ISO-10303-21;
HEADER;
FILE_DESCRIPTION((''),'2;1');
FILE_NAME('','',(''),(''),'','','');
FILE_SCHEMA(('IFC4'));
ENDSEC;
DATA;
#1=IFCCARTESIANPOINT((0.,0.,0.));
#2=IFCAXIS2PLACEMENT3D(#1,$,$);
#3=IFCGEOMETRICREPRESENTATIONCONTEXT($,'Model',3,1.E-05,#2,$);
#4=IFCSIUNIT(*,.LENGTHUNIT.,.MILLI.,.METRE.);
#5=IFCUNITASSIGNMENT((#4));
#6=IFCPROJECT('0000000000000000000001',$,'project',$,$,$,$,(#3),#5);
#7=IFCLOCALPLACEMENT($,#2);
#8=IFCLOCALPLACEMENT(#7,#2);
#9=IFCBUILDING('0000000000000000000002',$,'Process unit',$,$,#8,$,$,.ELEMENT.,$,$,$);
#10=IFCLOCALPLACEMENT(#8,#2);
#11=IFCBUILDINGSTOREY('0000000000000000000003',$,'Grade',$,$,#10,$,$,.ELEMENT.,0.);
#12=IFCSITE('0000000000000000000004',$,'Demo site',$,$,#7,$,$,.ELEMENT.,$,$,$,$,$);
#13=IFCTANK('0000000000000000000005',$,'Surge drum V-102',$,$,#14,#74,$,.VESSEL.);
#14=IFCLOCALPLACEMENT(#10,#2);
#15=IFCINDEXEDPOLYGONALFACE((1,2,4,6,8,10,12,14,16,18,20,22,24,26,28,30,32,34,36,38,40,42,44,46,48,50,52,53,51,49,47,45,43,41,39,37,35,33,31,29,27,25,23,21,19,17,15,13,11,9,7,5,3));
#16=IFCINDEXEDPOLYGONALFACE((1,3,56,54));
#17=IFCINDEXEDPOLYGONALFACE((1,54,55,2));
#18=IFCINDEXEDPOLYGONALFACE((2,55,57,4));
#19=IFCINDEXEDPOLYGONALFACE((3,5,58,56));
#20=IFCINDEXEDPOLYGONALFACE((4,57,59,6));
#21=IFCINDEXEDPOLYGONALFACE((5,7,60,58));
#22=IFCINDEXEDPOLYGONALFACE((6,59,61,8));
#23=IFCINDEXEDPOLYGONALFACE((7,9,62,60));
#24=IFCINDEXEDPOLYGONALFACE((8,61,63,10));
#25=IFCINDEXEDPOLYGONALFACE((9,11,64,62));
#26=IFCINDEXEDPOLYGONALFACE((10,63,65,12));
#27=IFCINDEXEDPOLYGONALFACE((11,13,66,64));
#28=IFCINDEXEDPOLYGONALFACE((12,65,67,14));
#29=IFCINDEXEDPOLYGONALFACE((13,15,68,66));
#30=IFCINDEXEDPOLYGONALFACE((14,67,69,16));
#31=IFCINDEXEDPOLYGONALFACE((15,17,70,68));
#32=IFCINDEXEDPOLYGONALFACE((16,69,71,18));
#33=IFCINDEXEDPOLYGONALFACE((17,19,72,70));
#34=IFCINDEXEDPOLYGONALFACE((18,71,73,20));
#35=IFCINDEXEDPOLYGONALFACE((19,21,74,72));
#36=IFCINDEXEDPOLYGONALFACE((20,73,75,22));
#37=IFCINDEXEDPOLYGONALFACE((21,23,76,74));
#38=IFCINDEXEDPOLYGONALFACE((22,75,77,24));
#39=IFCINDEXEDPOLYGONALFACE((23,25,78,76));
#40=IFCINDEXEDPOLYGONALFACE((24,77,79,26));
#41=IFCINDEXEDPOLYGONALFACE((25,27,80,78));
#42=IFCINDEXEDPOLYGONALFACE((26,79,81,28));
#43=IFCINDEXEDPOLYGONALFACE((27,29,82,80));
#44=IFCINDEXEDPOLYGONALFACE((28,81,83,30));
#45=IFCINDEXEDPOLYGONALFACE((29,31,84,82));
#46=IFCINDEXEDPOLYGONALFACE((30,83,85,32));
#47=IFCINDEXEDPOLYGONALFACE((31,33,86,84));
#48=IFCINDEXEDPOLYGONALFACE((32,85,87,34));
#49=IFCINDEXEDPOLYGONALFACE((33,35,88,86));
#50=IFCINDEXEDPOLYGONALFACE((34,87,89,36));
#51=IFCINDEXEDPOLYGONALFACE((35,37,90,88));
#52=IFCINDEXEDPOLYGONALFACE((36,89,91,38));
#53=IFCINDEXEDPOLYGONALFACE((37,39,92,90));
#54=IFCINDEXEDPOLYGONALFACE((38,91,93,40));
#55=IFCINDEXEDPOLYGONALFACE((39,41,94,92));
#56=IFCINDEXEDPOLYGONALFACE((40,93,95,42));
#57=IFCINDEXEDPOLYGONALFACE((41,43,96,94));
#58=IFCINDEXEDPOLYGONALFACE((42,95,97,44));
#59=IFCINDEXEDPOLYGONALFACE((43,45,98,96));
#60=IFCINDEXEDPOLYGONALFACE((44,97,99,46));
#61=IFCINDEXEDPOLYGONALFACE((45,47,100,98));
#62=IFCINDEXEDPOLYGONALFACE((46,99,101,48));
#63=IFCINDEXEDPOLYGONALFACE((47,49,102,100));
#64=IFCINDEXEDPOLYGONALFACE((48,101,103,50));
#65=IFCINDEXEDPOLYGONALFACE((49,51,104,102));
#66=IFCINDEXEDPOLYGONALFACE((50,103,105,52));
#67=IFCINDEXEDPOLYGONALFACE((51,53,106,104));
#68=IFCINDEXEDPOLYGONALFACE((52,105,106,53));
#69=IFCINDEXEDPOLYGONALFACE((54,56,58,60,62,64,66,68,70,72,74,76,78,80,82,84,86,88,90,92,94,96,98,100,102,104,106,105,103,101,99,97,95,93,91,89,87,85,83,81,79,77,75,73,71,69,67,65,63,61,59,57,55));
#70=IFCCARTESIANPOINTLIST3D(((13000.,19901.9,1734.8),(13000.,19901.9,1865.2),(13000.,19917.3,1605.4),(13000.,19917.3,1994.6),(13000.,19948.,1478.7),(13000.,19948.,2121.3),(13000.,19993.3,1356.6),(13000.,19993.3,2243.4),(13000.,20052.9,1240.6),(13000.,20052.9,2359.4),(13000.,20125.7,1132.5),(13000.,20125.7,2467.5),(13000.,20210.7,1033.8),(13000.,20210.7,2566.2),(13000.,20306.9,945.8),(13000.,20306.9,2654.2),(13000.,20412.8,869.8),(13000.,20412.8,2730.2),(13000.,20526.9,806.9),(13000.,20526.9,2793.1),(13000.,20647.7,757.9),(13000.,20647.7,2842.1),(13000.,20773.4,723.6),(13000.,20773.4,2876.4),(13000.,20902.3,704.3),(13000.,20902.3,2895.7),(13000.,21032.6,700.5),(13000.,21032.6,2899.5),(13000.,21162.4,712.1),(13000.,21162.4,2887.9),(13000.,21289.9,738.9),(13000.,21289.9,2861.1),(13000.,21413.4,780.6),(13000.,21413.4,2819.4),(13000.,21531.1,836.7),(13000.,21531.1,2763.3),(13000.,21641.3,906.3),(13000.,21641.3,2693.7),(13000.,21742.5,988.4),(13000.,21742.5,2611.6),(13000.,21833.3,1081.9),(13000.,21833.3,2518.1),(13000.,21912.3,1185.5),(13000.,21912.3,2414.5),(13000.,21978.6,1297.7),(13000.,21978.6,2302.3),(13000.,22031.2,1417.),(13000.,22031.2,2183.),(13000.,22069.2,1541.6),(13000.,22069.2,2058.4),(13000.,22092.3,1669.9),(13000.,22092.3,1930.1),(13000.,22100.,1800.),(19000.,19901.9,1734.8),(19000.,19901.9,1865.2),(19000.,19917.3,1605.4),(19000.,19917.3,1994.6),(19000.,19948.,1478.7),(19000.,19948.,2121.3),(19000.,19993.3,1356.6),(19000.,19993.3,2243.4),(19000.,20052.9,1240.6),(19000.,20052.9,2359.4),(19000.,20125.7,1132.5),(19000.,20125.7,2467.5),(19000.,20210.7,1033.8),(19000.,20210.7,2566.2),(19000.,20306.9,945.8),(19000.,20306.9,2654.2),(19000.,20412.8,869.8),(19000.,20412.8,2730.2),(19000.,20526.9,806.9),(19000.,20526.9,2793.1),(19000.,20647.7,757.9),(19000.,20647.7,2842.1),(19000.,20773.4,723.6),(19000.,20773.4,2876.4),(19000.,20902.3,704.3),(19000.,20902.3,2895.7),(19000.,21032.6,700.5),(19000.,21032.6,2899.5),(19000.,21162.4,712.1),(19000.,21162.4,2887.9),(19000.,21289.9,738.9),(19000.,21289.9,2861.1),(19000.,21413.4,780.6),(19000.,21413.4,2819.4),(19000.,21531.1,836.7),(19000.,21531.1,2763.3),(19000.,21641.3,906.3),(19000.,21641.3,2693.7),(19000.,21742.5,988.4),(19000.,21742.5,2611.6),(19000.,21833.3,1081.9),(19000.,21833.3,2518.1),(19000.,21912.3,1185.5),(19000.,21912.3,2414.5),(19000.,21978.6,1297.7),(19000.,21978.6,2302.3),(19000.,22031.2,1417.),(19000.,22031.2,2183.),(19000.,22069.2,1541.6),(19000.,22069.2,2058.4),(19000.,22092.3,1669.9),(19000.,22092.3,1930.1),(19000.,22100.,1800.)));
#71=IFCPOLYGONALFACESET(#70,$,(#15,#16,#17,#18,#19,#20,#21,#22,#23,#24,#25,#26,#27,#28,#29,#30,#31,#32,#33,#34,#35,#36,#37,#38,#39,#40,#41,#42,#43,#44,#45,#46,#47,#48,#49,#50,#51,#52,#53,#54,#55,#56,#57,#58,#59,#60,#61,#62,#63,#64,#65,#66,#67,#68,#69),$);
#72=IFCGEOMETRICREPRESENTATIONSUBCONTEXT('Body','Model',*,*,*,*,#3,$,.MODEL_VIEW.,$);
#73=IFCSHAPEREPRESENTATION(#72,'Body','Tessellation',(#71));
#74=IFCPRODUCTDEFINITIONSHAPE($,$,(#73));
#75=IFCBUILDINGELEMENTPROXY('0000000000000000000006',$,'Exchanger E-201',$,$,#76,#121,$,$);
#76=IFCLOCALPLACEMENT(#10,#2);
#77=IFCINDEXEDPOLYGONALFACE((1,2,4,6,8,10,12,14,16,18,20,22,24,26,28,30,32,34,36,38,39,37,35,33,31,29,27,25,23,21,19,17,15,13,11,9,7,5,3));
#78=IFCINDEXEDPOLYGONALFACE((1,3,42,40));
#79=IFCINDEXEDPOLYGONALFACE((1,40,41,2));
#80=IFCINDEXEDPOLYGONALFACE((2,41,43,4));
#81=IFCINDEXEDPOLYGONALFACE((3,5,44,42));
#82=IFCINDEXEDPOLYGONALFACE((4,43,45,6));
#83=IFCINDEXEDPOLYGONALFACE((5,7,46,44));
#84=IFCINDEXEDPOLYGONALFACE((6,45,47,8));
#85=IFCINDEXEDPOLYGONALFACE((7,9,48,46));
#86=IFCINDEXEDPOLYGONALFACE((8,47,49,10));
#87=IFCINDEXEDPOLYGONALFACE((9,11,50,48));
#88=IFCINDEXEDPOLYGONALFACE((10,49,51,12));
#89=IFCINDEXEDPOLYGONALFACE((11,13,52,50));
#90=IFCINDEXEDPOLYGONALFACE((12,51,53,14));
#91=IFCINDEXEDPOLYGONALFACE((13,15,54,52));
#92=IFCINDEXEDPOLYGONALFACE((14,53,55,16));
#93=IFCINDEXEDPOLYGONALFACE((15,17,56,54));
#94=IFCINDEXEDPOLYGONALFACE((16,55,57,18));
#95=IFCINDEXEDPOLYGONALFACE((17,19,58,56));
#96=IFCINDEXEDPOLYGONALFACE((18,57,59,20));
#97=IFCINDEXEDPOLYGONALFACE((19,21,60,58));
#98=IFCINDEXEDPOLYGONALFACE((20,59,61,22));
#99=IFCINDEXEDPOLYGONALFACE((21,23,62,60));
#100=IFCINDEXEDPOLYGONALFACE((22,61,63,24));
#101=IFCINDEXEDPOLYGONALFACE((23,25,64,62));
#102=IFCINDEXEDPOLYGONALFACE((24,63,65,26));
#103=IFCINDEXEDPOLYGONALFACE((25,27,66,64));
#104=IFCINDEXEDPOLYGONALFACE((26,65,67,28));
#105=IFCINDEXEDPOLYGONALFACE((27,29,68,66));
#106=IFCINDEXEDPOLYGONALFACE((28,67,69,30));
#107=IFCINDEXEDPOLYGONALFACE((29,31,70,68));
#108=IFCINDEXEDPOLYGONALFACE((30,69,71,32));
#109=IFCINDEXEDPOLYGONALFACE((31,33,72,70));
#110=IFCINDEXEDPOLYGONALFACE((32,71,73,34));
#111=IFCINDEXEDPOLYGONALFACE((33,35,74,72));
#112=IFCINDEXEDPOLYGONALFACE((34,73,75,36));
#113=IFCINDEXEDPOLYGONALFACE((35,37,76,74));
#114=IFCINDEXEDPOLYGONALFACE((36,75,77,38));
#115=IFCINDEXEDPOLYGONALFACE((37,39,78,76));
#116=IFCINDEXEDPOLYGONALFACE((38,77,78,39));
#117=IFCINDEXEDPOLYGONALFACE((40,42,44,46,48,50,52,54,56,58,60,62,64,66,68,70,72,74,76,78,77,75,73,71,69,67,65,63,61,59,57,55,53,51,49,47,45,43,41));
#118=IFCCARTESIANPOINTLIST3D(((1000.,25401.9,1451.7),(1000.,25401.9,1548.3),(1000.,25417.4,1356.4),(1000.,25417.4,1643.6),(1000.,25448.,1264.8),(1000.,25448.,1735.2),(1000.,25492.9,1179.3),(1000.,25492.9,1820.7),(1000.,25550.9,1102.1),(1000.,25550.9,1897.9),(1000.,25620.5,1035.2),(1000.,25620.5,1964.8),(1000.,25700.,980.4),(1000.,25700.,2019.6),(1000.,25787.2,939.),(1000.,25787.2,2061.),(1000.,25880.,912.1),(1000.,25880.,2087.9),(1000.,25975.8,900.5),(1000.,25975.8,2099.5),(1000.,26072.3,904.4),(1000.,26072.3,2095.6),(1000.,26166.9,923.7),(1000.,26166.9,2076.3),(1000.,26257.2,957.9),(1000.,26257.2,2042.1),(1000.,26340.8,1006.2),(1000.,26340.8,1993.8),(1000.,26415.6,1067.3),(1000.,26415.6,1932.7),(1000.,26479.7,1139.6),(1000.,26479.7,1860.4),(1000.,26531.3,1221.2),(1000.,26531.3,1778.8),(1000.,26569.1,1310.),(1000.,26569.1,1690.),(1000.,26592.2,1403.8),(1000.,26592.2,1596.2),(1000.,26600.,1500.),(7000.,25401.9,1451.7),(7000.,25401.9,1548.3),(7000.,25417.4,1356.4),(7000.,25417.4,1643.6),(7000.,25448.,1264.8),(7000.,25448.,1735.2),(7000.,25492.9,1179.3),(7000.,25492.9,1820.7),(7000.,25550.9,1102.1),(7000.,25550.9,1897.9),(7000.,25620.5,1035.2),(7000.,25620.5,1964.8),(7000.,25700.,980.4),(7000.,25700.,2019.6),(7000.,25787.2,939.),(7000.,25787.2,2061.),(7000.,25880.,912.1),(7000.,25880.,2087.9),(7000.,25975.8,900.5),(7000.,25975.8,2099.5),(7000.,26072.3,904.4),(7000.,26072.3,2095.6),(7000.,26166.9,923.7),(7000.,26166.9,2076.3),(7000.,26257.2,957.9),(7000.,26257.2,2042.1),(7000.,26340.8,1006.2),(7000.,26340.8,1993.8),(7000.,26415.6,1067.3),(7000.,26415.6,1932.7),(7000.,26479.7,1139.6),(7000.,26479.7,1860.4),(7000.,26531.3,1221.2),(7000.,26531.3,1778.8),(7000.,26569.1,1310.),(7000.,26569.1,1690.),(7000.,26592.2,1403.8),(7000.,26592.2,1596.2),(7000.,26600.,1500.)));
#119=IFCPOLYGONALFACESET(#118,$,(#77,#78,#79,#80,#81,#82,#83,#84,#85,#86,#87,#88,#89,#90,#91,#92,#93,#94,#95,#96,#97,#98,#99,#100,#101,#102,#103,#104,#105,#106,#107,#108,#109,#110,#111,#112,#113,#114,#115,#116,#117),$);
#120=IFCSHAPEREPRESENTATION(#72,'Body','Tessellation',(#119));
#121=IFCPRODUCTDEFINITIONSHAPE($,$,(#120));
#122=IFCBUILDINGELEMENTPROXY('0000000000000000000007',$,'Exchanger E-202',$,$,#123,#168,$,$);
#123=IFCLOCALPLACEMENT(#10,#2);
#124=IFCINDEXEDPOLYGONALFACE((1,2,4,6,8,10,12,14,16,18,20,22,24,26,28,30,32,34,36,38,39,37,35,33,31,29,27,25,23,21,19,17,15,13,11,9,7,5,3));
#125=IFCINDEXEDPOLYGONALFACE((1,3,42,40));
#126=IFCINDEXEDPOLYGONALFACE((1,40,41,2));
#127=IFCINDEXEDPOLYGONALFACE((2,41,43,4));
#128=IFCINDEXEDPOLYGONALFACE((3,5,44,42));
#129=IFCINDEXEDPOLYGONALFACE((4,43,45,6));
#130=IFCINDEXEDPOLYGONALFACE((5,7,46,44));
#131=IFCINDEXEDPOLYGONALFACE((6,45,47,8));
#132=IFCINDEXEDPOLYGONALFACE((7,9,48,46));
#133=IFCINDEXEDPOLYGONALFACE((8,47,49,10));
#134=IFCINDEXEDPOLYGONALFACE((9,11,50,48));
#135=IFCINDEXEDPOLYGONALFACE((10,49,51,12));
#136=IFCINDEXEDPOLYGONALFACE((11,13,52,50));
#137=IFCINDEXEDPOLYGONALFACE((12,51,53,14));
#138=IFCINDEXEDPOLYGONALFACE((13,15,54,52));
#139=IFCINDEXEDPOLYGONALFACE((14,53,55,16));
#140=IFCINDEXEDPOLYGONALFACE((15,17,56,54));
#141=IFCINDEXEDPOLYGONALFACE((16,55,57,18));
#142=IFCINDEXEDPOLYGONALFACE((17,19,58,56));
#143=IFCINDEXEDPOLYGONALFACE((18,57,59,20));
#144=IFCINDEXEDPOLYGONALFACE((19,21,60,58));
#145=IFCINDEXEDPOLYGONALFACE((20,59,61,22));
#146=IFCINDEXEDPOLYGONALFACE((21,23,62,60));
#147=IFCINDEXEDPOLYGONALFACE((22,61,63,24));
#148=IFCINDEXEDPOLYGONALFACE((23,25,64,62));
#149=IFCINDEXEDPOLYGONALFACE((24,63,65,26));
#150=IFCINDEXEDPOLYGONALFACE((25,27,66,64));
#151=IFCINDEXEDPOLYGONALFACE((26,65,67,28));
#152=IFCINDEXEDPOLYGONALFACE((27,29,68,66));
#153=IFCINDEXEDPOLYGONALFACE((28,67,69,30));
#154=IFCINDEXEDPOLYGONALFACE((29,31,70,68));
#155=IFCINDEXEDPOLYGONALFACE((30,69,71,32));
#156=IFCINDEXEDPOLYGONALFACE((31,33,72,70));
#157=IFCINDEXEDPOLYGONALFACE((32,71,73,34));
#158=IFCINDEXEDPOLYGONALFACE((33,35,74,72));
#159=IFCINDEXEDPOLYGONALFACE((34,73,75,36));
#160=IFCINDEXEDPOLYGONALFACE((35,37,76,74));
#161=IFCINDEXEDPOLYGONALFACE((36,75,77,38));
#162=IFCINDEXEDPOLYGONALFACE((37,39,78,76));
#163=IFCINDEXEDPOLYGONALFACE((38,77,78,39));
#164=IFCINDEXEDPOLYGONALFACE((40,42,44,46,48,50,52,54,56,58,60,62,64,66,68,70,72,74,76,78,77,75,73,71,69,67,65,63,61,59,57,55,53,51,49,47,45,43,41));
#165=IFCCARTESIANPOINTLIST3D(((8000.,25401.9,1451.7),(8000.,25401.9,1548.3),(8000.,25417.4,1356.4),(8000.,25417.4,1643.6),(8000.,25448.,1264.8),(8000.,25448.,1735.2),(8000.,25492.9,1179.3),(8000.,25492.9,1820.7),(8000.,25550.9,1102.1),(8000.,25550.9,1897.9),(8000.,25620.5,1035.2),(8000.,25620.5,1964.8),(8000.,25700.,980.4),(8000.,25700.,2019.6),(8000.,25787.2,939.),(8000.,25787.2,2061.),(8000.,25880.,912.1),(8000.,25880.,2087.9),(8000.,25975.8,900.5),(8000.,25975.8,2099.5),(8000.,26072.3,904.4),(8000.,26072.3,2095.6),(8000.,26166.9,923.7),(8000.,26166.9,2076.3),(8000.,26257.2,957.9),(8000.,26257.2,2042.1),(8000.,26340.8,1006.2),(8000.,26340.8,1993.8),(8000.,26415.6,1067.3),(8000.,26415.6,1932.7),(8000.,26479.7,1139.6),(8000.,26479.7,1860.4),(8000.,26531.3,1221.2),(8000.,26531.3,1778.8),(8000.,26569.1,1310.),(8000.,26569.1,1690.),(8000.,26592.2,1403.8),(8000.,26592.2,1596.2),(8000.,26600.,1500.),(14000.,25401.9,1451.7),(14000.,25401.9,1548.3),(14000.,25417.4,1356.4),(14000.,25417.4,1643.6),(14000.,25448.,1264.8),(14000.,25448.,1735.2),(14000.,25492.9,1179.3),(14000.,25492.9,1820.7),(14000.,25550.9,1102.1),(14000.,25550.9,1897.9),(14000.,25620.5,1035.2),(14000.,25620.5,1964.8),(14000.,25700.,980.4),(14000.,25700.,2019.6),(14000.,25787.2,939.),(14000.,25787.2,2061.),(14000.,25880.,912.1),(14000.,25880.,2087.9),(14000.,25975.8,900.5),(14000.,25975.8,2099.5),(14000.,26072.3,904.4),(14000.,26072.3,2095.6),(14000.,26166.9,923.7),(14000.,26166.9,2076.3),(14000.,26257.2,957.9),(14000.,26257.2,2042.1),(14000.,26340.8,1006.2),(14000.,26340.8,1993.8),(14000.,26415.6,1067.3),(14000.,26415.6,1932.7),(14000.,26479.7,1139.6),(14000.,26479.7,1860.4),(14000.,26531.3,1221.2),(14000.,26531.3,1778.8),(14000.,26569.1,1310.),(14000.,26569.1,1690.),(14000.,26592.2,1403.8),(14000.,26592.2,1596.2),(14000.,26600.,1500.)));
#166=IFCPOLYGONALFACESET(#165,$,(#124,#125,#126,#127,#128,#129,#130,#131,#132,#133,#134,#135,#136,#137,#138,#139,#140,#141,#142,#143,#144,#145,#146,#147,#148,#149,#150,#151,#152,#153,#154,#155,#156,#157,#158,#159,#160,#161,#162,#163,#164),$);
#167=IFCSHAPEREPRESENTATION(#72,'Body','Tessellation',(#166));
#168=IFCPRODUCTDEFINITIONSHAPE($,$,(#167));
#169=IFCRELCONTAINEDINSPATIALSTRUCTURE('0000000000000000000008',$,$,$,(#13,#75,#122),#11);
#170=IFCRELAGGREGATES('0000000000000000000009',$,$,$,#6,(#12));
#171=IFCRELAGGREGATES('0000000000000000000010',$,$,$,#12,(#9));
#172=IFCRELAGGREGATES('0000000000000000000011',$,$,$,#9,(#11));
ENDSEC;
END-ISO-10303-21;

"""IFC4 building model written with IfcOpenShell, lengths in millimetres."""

from ifc_helpers import new_model, si_unit, frame, origin, place, context, subcontext, project, spatial, circle, extrude, source, transform, mapped, element, save


model = new_model("IFC4")

# Units and contexts
model_context = context("Model", 3, precision=1e-05, world=origin())
body_context = subcontext(model_context, "Body", "Model", "MODEL_VIEW")
ifc_project = project(units=[si_unit("LENGTHUNIT", "METRE", prefix="MILLI")], contexts=[model_context])

# Site, building, storey
site_placement = place(None, origin())
site = spatial("IfcSite", under=ifc_project, at=site_placement, Name="Demo site", CompositionType="ELEMENT")
building_placement = place(site_placement, origin())
building = spatial("IfcBuilding", under=site, at=building_placement, Name="Process unit", CompositionType="ELEMENT")
storey_placement = place(building_placement, origin())
storey = spatial("IfcBuildingStorey", under=building, at=storey_placement, Name="Grade", CompositionType="ELEMENT", Elevation=0.0)

# Tank
tank_1_placement = place(storey_placement, frame((13000.0, 21000.0, 1800.0)))
element("IfcTank", 1, at=tank_1_placement, inside=storey, Name="Surge drum V-102", PredefinedType="VESSEL", context=body_context, shape_type="SweptSolid", body=[
    extrude(circle(Radius=1100.0), frame((0.0, 0.0, 0.0), z_axis=(1.0, 0.0, 0.0), x_axis=(0.0, 1.0, 0.0)), (0.0, 0.0, 1.0), 6000.0),
])

# Building element proxies
shared_shape = source(origin(), body_context, "Body", "SweptSolid", [
    extrude(circle(Radius=600.0), frame((0.0, 0.0, 0.0), z_axis=(1.0, 0.0, 0.0), x_axis=(0.0, 1.0, 0.0)), (0.0, 0.0, 1.0), 6000.0),
])
for number, where, name in (
    (2, (1000.0, 26000.0, 1500.0), "Exchanger E-201"),
    (3, (8000.0, 26000.0, 1500.0), "Exchanger E-202"),
):
    element("IfcBuildingElementProxy", number, at=place(storey_placement, frame(where)), inside=storey, Name=name, context=body_context, shape_type="SweptSolid", body=[
        mapped(shared_shape, transform((0.0, 0.0, 0.0), scale=1.0)),
    ])

save(model, "model.ifc")
